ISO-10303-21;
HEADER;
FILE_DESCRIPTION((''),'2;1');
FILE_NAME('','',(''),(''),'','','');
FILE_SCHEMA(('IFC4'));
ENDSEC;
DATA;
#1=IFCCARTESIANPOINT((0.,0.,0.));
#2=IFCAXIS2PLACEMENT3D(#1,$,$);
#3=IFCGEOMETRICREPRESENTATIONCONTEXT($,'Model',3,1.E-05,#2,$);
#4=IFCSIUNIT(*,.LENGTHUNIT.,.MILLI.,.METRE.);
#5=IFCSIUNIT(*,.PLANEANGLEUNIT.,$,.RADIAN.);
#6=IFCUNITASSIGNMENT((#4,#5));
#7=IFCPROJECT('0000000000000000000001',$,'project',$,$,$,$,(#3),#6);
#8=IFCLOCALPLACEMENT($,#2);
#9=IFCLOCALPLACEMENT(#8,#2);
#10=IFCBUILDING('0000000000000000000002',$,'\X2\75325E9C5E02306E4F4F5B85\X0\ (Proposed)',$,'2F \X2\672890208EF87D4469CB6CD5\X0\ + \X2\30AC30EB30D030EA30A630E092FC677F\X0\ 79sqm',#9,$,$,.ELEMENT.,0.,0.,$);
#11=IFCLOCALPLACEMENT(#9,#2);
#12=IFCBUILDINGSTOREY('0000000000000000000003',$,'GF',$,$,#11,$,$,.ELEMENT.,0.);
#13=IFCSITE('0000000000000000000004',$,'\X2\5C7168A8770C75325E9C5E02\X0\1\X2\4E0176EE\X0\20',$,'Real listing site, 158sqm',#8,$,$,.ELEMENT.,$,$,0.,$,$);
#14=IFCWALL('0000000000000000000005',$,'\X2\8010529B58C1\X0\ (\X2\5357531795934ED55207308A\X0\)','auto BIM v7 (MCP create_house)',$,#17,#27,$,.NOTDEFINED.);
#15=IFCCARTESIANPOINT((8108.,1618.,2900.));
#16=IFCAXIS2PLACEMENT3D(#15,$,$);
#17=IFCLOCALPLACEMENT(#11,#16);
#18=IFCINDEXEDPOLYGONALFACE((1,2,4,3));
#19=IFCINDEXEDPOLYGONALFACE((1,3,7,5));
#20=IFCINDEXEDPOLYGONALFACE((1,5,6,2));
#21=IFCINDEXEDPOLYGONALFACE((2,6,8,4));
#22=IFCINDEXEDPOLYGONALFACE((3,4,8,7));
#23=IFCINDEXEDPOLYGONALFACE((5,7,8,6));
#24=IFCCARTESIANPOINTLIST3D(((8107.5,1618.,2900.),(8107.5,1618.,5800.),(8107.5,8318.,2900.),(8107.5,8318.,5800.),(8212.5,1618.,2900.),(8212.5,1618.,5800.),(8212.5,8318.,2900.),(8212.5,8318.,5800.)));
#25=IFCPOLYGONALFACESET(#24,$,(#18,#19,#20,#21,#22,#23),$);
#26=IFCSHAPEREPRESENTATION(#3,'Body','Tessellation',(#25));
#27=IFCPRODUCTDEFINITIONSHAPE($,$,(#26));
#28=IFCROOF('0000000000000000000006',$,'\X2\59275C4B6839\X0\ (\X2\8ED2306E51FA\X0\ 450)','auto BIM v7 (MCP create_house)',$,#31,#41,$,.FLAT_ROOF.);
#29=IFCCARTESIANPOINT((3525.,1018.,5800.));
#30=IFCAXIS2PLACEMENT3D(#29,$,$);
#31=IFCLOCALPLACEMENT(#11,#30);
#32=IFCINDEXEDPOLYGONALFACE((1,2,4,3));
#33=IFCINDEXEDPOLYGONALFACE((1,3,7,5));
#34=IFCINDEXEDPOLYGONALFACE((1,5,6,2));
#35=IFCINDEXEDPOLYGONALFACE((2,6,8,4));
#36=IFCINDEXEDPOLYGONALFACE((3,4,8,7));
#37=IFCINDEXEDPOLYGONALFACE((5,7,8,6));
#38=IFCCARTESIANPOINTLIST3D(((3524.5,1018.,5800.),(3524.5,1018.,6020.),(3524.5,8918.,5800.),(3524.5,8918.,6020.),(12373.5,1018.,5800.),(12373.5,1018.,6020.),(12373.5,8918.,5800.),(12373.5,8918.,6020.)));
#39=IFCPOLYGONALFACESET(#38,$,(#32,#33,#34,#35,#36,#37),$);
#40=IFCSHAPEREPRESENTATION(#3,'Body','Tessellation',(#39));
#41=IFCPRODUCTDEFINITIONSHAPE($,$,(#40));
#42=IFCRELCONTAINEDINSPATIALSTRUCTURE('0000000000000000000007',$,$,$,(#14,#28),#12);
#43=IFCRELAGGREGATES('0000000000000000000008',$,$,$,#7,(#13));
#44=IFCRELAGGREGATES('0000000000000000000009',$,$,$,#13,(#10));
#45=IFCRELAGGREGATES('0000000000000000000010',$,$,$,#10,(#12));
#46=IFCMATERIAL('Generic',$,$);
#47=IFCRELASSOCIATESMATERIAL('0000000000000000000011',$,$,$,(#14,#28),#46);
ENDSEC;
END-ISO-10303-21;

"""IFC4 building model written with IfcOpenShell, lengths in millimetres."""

from ifc_helpers import new_model, si_unit, frame, frame_2d, origin, place, context, project, spatial, rectangle, extrude, material, element, save


model = new_model("IFC4")

# Units and contexts
model_context = context("Model", 3, precision=1e-05, world=origin())
ifc_project = project(units=[si_unit("LENGTHUNIT", "METRE", prefix="MILLI"), si_unit("PLANEANGLEUNIT", "RADIAN")], contexts=[model_context])

# Site, building, storey
site_placement = place(None, origin())
site = spatial("IfcSite", under=ifc_project, at=site_placement, Name="山梨県甲府市1丁目20", ObjectType="Real listing site, 158sqm", CompositionType="ELEMENT", RefElevation=0.0)
building_placement = place(site_placement, origin())
building = spatial("IfcBuilding", under=site, at=building_placement, Name="甲府市の住宅 (Proposed)", ObjectType="2F 木造軸組構法 + ガルバリウム鋼板 79sqm", CompositionType="ELEMENT", ElevationOfRefHeight=0.0, ElevationOfTerrain=0.0)
storey_placement = place(building_placement, origin())
storey = spatial("IfcBuildingStorey", under=building, at=storey_placement, Name="GF", CompositionType="ELEMENT", Elevation=0.0)

# Shared definitions
ifc_material = material(Name="Generic")

# Wall
wall_1_placement = place(storey_placement, frame((8108.0, 1618.0, 2900.0)))
element("IfcWall", 1, at=wall_1_placement, inside=storey, material=ifc_material, Name="耐力壁 (南北間仕切り)", Description="auto BIM v7 (MCP create_house)", PredefinedType="NOTDEFINED", context=model_context, shape_type="SweptSolid", body=[
    extrude(rectangle(XDim=105.0, YDim=6700.0, at=frame_2d((52.0, 3350.0))), frame((8108.0, 1618.0, 2900.0)), (0.0, 0.0, 1.0), 2900.0),
])

# Roof
roof_placement = place(storey_placement, frame((3525.0, 1018.0, 5800.0)))
element("IfcRoof", 2, at=roof_placement, inside=storey, material=ifc_material, Name="大屋根 (軒の出 450)", Description="auto BIM v7 (MCP create_house)", PredefinedType="FLAT_ROOF", context=model_context, shape_type="SweptSolid", body=[
    extrude(rectangle(XDim=8849.0, YDim=7900.0, at=frame_2d((4424.0, 3950.0))), frame((3525.0, 1018.0, 5800.0)), (0.0, 0.0, 1.0), 220.0),
])

save(model, "model.ifc")
